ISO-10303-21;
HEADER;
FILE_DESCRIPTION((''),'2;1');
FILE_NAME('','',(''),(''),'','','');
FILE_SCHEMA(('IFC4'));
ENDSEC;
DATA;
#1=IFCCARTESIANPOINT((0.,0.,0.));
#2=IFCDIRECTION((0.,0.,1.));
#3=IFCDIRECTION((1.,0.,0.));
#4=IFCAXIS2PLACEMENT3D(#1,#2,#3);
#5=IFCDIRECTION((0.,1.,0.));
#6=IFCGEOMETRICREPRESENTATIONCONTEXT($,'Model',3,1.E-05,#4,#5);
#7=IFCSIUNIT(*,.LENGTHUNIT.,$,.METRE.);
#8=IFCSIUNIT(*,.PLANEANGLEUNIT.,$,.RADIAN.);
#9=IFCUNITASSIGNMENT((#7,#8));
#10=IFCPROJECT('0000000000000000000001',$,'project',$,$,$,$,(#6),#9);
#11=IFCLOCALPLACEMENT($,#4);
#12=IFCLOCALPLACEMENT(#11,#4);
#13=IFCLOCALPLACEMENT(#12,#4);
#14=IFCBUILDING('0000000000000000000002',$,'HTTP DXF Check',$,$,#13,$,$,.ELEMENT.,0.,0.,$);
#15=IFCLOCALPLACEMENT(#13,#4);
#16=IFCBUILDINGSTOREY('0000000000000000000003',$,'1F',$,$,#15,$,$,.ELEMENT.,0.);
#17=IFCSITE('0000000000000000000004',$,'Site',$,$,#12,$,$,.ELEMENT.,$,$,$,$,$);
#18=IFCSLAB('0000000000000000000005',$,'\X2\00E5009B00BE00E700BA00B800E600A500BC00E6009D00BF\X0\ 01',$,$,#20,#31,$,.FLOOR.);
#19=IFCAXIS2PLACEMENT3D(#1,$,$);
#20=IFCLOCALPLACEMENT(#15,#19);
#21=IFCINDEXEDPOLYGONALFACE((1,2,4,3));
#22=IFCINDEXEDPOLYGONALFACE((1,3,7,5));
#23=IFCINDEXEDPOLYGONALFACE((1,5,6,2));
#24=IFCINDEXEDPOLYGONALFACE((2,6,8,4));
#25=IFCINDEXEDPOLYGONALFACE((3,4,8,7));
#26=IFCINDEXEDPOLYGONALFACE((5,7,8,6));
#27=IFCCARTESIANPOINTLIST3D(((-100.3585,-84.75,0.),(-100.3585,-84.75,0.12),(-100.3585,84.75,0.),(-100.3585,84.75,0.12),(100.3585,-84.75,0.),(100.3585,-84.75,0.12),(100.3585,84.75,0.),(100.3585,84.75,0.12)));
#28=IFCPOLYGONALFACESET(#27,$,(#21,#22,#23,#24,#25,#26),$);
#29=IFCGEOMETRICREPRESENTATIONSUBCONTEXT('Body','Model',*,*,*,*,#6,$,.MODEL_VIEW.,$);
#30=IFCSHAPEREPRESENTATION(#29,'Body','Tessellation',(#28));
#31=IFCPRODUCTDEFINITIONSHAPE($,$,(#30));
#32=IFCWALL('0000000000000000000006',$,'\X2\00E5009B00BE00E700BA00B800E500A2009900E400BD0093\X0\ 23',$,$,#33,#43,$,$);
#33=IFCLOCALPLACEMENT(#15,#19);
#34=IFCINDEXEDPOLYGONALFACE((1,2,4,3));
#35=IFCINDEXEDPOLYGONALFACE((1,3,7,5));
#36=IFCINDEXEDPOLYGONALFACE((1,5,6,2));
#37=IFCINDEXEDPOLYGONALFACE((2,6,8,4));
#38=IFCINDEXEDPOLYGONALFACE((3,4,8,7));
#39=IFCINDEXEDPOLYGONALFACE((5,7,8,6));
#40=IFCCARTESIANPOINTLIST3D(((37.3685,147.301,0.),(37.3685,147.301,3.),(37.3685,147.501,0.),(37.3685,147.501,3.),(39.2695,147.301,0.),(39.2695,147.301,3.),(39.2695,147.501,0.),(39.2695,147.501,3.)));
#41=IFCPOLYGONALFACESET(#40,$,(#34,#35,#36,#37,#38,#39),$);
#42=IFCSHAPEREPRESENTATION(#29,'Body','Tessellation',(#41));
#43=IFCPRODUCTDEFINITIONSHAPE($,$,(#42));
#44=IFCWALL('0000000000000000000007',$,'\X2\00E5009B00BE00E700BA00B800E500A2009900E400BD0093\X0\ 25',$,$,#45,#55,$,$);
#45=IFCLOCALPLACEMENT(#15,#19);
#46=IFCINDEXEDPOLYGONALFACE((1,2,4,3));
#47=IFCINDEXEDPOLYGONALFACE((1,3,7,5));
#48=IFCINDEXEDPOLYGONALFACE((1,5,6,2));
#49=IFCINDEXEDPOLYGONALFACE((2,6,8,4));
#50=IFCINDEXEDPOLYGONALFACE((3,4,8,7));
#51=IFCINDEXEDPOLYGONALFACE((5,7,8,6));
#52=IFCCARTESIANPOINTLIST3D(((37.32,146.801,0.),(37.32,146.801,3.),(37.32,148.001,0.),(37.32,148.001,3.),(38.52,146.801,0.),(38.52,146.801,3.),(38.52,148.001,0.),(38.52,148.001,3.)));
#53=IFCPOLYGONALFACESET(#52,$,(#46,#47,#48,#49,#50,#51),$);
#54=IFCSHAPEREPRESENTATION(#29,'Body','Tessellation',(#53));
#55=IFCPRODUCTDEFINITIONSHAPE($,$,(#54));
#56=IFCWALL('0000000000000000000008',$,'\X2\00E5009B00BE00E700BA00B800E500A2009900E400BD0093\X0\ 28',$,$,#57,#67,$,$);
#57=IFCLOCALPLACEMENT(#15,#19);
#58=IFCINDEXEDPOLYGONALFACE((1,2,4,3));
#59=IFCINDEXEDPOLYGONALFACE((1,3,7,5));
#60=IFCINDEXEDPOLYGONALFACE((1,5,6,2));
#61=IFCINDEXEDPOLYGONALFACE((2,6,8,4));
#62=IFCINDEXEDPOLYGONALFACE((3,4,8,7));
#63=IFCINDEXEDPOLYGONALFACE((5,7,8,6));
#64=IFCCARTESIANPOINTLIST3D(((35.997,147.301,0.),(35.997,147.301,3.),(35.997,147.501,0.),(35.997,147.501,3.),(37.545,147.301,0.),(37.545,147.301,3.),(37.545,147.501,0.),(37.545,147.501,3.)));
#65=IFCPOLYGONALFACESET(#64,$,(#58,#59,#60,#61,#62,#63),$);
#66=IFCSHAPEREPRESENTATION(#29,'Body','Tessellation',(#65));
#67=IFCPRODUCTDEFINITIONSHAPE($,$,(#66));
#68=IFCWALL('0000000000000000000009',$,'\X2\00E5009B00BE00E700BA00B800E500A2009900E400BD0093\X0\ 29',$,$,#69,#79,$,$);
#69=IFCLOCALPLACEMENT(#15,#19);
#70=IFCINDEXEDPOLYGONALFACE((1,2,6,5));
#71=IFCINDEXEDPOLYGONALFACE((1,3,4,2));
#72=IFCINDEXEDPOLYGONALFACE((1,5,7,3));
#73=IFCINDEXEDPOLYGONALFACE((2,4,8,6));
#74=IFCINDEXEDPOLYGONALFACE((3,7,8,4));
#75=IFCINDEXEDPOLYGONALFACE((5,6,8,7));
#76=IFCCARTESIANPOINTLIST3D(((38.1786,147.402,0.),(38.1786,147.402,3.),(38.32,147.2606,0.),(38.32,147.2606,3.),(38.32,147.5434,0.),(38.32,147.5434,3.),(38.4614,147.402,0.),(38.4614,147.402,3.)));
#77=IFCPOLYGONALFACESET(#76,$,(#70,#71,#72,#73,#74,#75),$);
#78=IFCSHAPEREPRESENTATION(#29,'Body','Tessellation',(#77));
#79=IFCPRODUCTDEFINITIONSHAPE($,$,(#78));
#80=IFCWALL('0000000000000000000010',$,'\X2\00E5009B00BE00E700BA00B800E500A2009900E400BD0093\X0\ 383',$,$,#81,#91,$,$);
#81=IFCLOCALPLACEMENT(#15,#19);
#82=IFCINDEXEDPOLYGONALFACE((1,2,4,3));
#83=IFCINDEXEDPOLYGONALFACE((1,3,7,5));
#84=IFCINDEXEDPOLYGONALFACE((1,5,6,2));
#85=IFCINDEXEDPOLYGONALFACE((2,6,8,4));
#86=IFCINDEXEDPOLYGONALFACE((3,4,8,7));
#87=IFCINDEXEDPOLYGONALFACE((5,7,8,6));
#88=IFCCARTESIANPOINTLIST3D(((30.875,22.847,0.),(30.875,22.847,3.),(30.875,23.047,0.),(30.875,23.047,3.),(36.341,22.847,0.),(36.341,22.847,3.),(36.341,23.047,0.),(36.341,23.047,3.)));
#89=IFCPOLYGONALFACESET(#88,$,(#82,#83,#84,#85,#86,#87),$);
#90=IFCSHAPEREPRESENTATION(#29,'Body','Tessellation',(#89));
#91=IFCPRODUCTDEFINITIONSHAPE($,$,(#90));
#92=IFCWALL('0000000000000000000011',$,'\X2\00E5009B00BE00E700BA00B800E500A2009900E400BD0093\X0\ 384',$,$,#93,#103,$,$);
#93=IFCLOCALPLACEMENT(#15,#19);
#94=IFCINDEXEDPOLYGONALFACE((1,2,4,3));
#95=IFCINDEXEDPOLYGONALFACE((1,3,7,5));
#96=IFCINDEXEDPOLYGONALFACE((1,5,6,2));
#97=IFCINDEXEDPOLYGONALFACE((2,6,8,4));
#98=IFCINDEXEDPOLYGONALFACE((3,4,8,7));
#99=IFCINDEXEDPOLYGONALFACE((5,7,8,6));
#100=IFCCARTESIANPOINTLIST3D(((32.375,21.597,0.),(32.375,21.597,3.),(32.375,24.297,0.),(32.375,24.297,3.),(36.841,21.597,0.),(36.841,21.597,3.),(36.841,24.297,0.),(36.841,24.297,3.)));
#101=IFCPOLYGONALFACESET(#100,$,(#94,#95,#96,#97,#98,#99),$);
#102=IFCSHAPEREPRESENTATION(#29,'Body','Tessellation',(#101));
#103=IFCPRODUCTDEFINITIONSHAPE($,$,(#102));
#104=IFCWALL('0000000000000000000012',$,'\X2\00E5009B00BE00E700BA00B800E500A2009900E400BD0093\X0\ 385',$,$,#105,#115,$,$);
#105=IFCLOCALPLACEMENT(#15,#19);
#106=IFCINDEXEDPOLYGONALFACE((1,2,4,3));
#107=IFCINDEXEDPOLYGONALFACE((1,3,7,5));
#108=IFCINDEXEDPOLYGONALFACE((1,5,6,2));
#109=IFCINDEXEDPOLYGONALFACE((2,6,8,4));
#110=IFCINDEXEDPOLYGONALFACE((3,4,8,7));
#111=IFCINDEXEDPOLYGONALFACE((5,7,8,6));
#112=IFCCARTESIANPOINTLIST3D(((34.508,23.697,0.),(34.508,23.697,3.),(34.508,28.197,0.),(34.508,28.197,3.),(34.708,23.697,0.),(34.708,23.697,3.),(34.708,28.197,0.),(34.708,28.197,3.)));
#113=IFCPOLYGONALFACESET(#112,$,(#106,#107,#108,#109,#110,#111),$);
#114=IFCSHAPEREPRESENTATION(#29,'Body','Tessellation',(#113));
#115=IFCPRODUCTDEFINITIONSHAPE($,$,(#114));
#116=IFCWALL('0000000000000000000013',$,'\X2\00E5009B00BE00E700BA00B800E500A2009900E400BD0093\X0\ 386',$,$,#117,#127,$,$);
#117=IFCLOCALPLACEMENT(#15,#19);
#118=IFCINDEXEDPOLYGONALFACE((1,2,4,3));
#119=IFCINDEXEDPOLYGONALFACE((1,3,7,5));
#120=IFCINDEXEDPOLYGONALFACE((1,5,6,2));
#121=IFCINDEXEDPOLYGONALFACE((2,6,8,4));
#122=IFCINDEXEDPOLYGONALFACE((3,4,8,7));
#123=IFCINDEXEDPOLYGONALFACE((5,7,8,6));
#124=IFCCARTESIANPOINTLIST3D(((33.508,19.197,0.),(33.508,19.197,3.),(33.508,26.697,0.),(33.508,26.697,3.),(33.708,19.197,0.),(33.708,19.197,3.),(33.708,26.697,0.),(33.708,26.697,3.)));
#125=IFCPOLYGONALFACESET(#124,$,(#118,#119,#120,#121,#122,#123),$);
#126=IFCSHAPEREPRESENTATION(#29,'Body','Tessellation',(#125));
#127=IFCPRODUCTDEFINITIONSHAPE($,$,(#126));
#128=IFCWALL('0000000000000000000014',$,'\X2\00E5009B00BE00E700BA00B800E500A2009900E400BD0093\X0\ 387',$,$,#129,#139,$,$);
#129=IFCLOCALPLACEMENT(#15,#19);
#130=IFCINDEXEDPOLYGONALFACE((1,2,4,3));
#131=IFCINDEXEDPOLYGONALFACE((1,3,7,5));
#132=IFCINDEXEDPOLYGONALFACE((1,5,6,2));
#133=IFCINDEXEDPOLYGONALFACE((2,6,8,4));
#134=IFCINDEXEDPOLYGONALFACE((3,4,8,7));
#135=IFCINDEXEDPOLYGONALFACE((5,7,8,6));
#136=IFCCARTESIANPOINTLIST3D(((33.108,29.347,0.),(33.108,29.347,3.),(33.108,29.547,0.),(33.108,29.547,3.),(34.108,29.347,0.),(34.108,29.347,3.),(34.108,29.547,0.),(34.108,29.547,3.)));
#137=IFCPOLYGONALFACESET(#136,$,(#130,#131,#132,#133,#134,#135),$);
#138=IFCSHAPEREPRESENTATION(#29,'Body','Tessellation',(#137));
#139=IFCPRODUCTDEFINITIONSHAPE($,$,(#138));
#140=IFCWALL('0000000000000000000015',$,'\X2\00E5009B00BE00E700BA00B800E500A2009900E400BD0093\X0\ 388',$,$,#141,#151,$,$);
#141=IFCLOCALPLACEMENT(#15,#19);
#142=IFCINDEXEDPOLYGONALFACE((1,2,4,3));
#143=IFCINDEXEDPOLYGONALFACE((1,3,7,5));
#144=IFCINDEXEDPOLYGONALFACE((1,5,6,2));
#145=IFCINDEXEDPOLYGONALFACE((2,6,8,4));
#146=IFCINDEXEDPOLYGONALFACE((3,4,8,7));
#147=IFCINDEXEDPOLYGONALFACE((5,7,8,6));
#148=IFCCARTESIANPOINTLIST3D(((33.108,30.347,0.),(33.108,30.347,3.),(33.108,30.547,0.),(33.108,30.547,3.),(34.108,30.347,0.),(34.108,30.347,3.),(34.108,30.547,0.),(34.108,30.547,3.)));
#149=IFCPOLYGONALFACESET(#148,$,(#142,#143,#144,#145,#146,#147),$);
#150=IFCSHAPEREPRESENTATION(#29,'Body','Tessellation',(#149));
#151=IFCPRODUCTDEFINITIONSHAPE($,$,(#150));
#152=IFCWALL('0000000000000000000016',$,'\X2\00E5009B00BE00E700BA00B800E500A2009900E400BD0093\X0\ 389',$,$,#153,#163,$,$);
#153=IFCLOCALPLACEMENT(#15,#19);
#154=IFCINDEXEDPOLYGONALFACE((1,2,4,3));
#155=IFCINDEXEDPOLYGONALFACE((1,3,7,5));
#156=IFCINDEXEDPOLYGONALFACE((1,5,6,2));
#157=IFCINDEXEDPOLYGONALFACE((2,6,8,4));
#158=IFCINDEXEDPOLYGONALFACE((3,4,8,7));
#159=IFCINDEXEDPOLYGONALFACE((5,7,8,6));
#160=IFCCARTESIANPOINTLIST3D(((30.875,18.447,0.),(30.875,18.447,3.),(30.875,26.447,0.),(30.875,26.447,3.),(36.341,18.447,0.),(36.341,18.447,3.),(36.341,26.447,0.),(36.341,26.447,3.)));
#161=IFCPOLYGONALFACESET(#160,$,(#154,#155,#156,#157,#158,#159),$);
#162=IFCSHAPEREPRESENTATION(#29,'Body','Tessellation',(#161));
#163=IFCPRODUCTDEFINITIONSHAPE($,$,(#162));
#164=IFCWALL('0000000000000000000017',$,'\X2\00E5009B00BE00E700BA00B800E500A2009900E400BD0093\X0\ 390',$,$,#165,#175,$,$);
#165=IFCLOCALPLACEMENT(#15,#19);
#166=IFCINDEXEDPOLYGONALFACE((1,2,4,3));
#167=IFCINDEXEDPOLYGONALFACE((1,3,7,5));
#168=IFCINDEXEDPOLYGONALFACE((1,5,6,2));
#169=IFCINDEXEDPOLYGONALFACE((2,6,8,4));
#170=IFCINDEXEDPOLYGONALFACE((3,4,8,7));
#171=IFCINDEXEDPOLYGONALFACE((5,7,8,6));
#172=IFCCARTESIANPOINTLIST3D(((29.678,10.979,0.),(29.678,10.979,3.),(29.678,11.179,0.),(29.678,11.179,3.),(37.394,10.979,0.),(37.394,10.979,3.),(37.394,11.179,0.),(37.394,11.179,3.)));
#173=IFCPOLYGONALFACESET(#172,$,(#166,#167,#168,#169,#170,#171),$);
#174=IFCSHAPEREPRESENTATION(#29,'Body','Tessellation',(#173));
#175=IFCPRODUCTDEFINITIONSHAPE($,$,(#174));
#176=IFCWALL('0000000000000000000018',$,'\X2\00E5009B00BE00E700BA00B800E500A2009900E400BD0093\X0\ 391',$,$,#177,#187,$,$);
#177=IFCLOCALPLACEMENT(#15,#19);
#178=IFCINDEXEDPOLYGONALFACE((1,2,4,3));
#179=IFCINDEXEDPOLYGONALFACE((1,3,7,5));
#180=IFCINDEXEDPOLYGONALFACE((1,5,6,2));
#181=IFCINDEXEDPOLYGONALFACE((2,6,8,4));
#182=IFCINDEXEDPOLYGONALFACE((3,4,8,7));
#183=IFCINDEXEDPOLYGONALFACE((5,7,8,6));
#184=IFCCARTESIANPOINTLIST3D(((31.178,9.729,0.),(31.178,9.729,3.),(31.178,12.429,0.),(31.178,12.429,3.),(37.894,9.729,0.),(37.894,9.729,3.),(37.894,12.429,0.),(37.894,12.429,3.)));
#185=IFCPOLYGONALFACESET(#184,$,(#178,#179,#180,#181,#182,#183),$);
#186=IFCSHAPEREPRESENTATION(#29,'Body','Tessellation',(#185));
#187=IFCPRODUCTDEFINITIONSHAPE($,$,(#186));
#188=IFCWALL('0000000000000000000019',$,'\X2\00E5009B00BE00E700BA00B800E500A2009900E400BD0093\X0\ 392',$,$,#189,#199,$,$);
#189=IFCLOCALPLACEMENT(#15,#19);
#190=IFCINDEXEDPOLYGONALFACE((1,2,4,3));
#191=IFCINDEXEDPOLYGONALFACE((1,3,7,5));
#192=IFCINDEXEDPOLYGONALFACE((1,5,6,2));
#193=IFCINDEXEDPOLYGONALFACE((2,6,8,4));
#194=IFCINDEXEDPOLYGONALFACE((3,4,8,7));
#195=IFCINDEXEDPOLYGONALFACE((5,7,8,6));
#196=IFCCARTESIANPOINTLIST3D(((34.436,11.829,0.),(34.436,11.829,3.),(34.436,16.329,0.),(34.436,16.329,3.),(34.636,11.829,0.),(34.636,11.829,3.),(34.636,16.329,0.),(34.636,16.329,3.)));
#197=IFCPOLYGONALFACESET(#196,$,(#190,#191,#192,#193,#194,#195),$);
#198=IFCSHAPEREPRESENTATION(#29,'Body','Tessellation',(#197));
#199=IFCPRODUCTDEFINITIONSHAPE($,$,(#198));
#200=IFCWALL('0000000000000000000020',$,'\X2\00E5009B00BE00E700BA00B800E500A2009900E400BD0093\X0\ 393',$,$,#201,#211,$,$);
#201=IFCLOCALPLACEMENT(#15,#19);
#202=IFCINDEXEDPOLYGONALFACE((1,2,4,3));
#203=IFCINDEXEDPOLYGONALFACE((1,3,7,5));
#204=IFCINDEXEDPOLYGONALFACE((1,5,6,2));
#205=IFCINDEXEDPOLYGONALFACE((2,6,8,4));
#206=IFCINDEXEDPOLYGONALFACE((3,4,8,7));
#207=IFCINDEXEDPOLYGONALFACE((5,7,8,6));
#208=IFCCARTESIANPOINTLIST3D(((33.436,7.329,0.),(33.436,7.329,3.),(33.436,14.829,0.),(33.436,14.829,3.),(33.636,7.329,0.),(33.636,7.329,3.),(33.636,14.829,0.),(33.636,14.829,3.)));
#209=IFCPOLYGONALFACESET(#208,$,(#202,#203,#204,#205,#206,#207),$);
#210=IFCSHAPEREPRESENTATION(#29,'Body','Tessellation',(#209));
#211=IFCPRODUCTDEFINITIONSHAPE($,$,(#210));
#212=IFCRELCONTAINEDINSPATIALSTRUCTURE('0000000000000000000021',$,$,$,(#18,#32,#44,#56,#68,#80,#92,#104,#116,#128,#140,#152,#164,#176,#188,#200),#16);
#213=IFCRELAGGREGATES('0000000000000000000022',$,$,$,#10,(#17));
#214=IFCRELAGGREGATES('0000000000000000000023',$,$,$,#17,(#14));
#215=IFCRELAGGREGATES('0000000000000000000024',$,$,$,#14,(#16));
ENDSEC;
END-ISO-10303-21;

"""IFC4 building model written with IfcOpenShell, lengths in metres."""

from ifc_helpers import new_model, si_unit, direction, frame, frame_2d, origin_with_axes, place, context, subcontext, project, spatial, rectangle, extrude, element, save


model = new_model("IFC4")

# Units and contexts
model_context = context("Model", 3, precision=1e-05, world=origin_with_axes(), true_north=direction((0.0, 1.0, 0.0)))
body_context = subcontext(model_context, "Body", "Model", "MODEL_VIEW")
ifc_project = project(units=[si_unit("LENGTHUNIT", "METRE"), si_unit("PLANEANGLEUNIT", "RADIAN")], contexts=[model_context])

# Site, building, storey
placement = place(None, origin_with_axes())
site_placement = place(placement, origin_with_axes())
site = spatial("IfcSite", under=ifc_project, at=site_placement, Name="Site", CompositionType="ELEMENT")
building_placement = place(site_placement, origin_with_axes())
building = spatial("IfcBuilding", under=site, at=building_placement, Name="HTTP DXF Check", CompositionType="ELEMENT", ElevationOfRefHeight=0.0, ElevationOfTerrain=0.0)
storey_placement = place(building_placement, origin_with_axes())
storey = spatial("IfcBuildingStorey", under=building, at=storey_placement, Name="1F", CompositionType="ELEMENT", Elevation=0.0)

# Slab
slab_placement = place(storey_placement, origin_with_axes())
element("IfcSlab", 1, at=slab_placement, inside=storey, Name="å\u009b¾çº¸æ¥¼æ\u009d¿ 01", PredefinedType="FLOOR", context=body_context, shape_type="SweptSolid", body=[
    extrude(rectangle(XDim=200.717, YDim=169.5, at=frame_2d((0.0, 0.0), x_axis=(1.0, 0.0, 0.0))), frame((0.0, 0.0, 0.0), z_axis=(0.0, 0.0, 1.0)), (0.0, 0.0, 1.0), 0.12),
])

# Walls
wall_1_placement = place(storey_placement, frame((38.319, 147.401, 0.0), z_axis=(0.0, 0.0, 1.0), x_axis=(1.0, 0.0, 0.0)))
element("IfcWall", 2, at=wall_1_placement, inside=storey, Name="å\u009b¾çº¸å¢\u0099ä½\u0093 23", context=body_context, shape_type="SweptSolid", body=[
    extrude(rectangle(XDim=1.901, YDim=0.2, at=frame_2d((0.0, 0.0), x_axis=(1.0, 0.0, 0.0))), frame((0.0, 0.0, 0.0), z_axis=(0.0, 0.0, 1.0)), (0.0, 0.0, 1.0), 3.0),
])
wall_2_placement = place(storey_placement, frame((37.92, 147.401, 0.0), z_axis=(0.0, 0.0, 1.0), x_axis=(1.0, 0.0, 0.0)))
element("IfcWall", 3, at=wall_2_placement, inside=storey, Name="å\u009b¾çº¸å¢\u0099ä½\u0093 25", context=body_context, shape_type="SweptSolid", body=[
    extrude(rectangle(XDim=1.2, YDim=1.2, at=frame_2d((0.0, 0.0), x_axis=(1.0, 0.0, 0.0))), frame((0.0, 0.0, 0.0), z_axis=(0.0, 0.0, 1.0)), (0.0, 0.0, 1.0), 3.0),
])
wall_3_placement = place(storey_placement, frame((36.771, 147.401, 0.0), z_axis=(0.0, 0.0, 1.0), x_axis=(1.0, 0.0, 0.0)))
element("IfcWall", 4, at=wall_3_placement, inside=storey, Name="å\u009b¾çº¸å¢\u0099ä½\u0093 28", context=body_context, shape_type="SweptSolid", body=[
    extrude(rectangle(XDim=1.548, YDim=0.2, at=frame_2d((0.0, 0.0), x_axis=(1.0, 0.0, 0.0))), frame((0.0, 0.0, 0.0), z_axis=(0.0, 0.0, 1.0)), (0.0, 0.0, 1.0), 3.0),
])
wall_4_placement = place(storey_placement, frame((38.32, 147.402, 0.0), z_axis=(0.0, 0.0, 1.0), x_axis=(-0.707107, -0.707107, 0.0)))
element("IfcWall", 5, at=wall_4_placement, inside=storey, Name="å\u009b¾çº¸å¢\u0099ä½\u0093 29", context=body_context, shape_type="SweptSolid", body=[
    extrude(rectangle(XDim=0.2, YDim=0.2, at=frame_2d((0.0, 0.0), x_axis=(1.0, 0.0, 0.0))), frame((0.0, 0.0, 0.0), z_axis=(0.0, 0.0, 1.0)), (0.0, 0.0, 1.0), 3.0),
])
wall_5_placement = place(storey_placement, frame((33.608, 22.947, 0.0), z_axis=(0.0, 0.0, 1.0), x_axis=(1.0, 0.0, 0.0)))
element("IfcWall", 6, at=wall_5_placement, inside=storey, Name="å\u009b¾çº¸å¢\u0099ä½\u0093 383", context=body_context, shape_type="SweptSolid", body=[
    extrude(rectangle(XDim=5.466, YDim=0.2, at=frame_2d((0.0, 0.0), x_axis=(1.0, 0.0, 0.0))), frame((0.0, 0.0, 0.0), z_axis=(0.0, 0.0, 1.0)), (0.0, 0.0, 1.0), 3.0),
])
wall_6_placement = place(storey_placement, frame((34.608, 22.947, 0.0), z_axis=(0.0, 0.0, 1.0), x_axis=(1.0, 0.0, 0.0)))
element("IfcWall", 7, at=wall_6_placement, inside=storey, Name="å\u009b¾çº¸å¢\u0099ä½\u0093 384", context=body_context, shape_type="SweptSolid", body=[
    extrude(rectangle(XDim=4.466, YDim=2.7, at=frame_2d((0.0, 0.0), x_axis=(1.0, 0.0, 0.0))), frame((0.0, 0.0, 0.0), z_axis=(0.0, 0.0, 1.0)), (0.0, 0.0, 1.0), 3.0),
])
wall_7_placement = place(storey_placement, frame((34.608, 25.947, 0.0), z_axis=(0.0, 0.0, 1.0), x_axis=(0.0, 1.0, 0.0)))
element("IfcWall", 8, at=wall_7_placement, inside=storey, Name="å\u009b¾çº¸å¢\u0099ä½\u0093 385", context=body_context, shape_type="SweptSolid", body=[
    extrude(rectangle(XDim=4.5, YDim=0.2, at=frame_2d((0.0, 0.0), x_axis=(1.0, 0.0, 0.0))), frame((0.0, 0.0, 0.0), z_axis=(0.0, 0.0, 1.0)), (0.0, 0.0, 1.0), 3.0),
])
wall_8_placement = place(storey_placement, frame((33.608, 22.947, 0.0), z_axis=(0.0, 0.0, 1.0), x_axis=(0.0, 1.0, 0.0)))
element("IfcWall", 9, at=wall_8_placement, inside=storey, Name="å\u009b¾çº¸å¢\u0099ä½\u0093 386", context=body_context, shape_type="SweptSolid", body=[
    extrude(rectangle(XDim=7.5, YDim=0.2, at=frame_2d((0.0, 0.0), x_axis=(1.0, 0.0, 0.0))), frame((0.0, 0.0, 0.0), z_axis=(0.0, 0.0, 1.0)), (0.0, 0.0, 1.0), 3.0),
])
for number, where, z_axis, x_axis, name in (
    (10, (33.608, 29.447, 0.0), (0.0, 0.0, 1.0), (1.0, 0.0, 0.0), "å\u009b¾çº¸å¢\u0099ä½\u0093 387"),
    (11, (33.608, 30.447, 0.0), (0.0, 0.0, 1.0), (1.0, 0.0, 0.0), "å\u009b¾çº¸å¢\u0099ä½\u0093 388"),
):
    element("IfcWall", number, at=place(storey_placement, frame(where, z_axis=z_axis, x_axis=x_axis)), inside=storey, Name=name, context=body_context, shape_type="SweptSolid", body=[
        extrude(rectangle(XDim=1.0, YDim=0.2, at=frame_2d((0.0, 0.0), x_axis=(1.0, 0.0, 0.0))), frame((0.0, 0.0, 0.0), z_axis=(0.0, 0.0, 1.0)), (0.0, 0.0, 1.0), 3.0),
    ])
wall_9_placement = place(storey_placement, frame((33.608, 22.447, 0.0), z_axis=(0.0, 0.0, 1.0), x_axis=(1.0, 0.0, 0.0)))
element("IfcWall", 12, at=wall_9_placement, inside=storey, Name="å\u009b¾çº¸å¢\u0099ä½\u0093 389", context=body_context, shape_type="SweptSolid", body=[
    extrude(rectangle(XDim=5.466, YDim=8.0, at=frame_2d((0.0, 0.0), x_axis=(1.0, 0.0, 0.0))), frame((0.0, 0.0, 0.0), z_axis=(0.0, 0.0, 1.0)), (0.0, 0.0, 1.0), 3.0),
])
wall_10_placement = place(storey_placement, frame((33.536, 11.079, 0.0), z_axis=(0.0, 0.0, 1.0), x_axis=(1.0, 0.0, 0.0)))
element("IfcWall", 13, at=wall_10_placement, inside=storey, Name="å\u009b¾çº¸å¢\u0099ä½\u0093 390", context=body_context, shape_type="SweptSolid", body=[
    extrude(rectangle(XDim=7.716, YDim=0.2, at=frame_2d((0.0, 0.0), x_axis=(1.0, 0.0, 0.0))), frame((0.0, 0.0, 0.0), z_axis=(0.0, 0.0, 1.0)), (0.0, 0.0, 1.0), 3.0),
])
wall_11_placement = place(storey_placement, frame((34.536, 11.079, 0.0), z_axis=(0.0, 0.0, 1.0), x_axis=(1.0, 0.0, 0.0)))
element("IfcWall", 14, at=wall_11_placement, inside=storey, Name="å\u009b¾çº¸å¢\u0099ä½\u0093 391", context=body_context, shape_type="SweptSolid", body=[
    extrude(rectangle(XDim=6.716, YDim=2.7, at=frame_2d((0.0, 0.0), x_axis=(1.0, 0.0, 0.0))), frame((0.0, 0.0, 0.0), z_axis=(0.0, 0.0, 1.0)), (0.0, 0.0, 1.0), 3.0),
])
wall_12_placement = place(storey_placement, frame((34.536, 14.079, 0.0), z_axis=(0.0, 0.0, 1.0), x_axis=(0.0, 1.0, 0.0)))
element("IfcWall", 15, at=wall_12_placement, inside=storey, Name="å\u009b¾çº¸å¢\u0099ä½\u0093 392", context=body_context, shape_type="SweptSolid", body=[
    extrude(rectangle(XDim=4.5, YDim=0.2, at=frame_2d((0.0, 0.0), x_axis=(1.0, 0.0, 0.0))), frame((0.0, 0.0, 0.0), z_axis=(0.0, 0.0, 1.0)), (0.0, 0.0, 1.0), 3.0),
])
wall_13_placement = place(storey_placement, frame((33.536, 11.079, 0.0), z_axis=(0.0, 0.0, 1.0), x_axis=(0.0, 1.0, 0.0)))
element("IfcWall", 16, at=wall_13_placement, inside=storey, Name="å\u009b¾çº¸å¢\u0099ä½\u0093 393", context=body_context, shape_type="SweptSolid", body=[
    extrude(rectangle(XDim=7.5, YDim=0.2, at=frame_2d((0.0, 0.0), x_axis=(1.0, 0.0, 0.0))), frame((0.0, 0.0, 0.0), z_axis=(0.0, 0.0, 1.0)), (0.0, 0.0, 1.0), 3.0),
])

save(model, "model.ifc")
